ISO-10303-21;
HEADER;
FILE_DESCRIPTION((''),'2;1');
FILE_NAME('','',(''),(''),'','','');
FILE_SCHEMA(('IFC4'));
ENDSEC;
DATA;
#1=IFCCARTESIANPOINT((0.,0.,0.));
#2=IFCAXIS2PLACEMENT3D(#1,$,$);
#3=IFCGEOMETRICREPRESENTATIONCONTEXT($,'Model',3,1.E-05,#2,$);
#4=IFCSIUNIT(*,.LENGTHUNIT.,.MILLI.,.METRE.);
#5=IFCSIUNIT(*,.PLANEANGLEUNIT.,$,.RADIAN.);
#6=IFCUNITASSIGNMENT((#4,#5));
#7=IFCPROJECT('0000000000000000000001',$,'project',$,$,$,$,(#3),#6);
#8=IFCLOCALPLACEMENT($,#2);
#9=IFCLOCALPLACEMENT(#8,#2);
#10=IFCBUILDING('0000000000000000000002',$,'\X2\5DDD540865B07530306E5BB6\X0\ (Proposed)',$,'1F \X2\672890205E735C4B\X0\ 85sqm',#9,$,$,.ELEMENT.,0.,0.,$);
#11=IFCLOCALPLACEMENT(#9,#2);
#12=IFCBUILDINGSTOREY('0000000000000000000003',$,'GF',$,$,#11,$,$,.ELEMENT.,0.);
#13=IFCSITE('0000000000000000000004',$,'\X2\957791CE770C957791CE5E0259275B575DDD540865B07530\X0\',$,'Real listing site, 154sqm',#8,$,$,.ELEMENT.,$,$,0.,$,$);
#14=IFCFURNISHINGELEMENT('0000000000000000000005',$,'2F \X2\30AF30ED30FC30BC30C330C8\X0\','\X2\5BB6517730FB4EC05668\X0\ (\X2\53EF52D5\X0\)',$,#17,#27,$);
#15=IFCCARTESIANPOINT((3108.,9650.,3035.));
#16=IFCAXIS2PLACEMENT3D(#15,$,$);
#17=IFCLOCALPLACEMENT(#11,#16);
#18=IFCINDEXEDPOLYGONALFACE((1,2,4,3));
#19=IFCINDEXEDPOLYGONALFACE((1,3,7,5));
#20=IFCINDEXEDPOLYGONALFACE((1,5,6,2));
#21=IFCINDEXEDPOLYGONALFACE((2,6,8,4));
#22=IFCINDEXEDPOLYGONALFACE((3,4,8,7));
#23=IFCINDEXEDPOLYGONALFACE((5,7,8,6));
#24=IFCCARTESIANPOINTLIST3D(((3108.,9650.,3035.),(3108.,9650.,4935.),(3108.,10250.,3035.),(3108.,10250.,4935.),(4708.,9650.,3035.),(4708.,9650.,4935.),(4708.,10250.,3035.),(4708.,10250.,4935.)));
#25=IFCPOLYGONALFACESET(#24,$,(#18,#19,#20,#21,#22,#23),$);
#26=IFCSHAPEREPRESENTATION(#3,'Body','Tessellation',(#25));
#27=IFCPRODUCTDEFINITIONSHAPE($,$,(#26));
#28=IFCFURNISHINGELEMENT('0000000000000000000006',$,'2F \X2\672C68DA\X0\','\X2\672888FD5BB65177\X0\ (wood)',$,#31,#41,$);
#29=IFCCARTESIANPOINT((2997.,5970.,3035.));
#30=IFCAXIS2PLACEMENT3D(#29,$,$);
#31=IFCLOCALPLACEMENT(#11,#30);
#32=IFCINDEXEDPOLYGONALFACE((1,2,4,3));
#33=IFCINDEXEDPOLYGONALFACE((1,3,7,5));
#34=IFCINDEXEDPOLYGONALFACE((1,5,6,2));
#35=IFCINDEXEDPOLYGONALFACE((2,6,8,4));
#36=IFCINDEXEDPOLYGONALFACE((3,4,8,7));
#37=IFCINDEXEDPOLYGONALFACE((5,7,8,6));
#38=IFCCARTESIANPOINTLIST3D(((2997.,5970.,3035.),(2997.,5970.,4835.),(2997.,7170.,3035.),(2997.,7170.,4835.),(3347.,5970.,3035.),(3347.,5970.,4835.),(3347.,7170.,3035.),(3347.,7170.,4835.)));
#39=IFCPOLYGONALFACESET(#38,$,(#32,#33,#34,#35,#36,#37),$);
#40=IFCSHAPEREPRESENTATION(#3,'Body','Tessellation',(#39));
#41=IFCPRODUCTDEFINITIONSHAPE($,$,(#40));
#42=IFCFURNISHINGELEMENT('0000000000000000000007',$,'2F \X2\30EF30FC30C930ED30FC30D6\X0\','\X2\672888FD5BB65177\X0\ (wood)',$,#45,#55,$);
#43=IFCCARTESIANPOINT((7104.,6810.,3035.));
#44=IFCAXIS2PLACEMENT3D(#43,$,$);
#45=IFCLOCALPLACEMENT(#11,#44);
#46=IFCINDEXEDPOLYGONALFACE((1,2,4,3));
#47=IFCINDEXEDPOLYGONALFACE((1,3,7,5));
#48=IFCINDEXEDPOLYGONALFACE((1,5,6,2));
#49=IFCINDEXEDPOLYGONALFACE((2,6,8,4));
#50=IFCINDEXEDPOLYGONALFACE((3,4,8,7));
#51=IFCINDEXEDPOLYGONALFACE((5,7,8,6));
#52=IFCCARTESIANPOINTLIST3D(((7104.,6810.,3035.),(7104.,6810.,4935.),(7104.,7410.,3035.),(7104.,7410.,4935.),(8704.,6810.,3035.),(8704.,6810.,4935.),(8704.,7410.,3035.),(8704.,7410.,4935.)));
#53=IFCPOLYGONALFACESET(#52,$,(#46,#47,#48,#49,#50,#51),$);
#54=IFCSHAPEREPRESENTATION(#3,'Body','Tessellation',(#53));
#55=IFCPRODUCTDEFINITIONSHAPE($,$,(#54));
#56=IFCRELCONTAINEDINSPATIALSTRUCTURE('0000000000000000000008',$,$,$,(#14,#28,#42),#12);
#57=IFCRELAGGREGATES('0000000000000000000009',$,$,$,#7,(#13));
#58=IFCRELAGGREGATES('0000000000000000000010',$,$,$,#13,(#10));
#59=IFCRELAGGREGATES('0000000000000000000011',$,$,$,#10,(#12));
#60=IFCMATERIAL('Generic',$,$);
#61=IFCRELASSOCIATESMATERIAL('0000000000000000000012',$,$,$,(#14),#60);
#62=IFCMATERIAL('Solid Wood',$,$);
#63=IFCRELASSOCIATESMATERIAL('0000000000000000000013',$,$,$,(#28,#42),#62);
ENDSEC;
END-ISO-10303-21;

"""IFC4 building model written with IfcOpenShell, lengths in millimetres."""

from ifc_helpers import new_model, si_unit, frame, frame_2d, origin, place, context, project, spatial, rectangle, extrude, material, element, save


model = new_model("IFC4")

# Units and contexts
model_context = context("Model", 3, precision=1e-05, world=origin())
ifc_project = project(units=[si_unit("LENGTHUNIT", "METRE", prefix="MILLI"), si_unit("PLANEANGLEUNIT", "RADIAN")], contexts=[model_context])

# Site, building, storey
site_placement = place(None, origin())
site = spatial("IfcSite", under=ifc_project, at=site_placement, Name="長野県長野市大字川合新田", ObjectType="Real listing site, 154sqm", CompositionType="ELEMENT", RefElevation=0.0)
building_placement = place(site_placement, origin())
building = spatial("IfcBuilding", under=site, at=building_placement, Name="川合新田の家 (Proposed)", ObjectType="1F 木造平屋 85sqm", CompositionType="ELEMENT", ElevationOfRefHeight=0.0, ElevationOfTerrain=0.0)
storey_placement = place(building_placement, origin())
storey = spatial("IfcBuildingStorey", under=building, at=storey_placement, Name="GF", CompositionType="ELEMENT", Elevation=0.0)

# Shared definitions
ifc_material_1 = material(Name="Solid Wood")

# Shared definitions
ifc_material_2 = material(Name="Generic")

# Furnishing elements
furnishing_1_placement = place(storey_placement, frame((3108.0, 9650.0, 3035.0)))
element("IfcFurnishingElement", 1, at=furnishing_1_placement, inside=storey, material=ifc_material_2, Name="2F クローゼット", Description="家具・什器 (可動)", context=model_context, shape_type="SweptSolid", body=[
    extrude(rectangle(XDim=1600.0, YDim=600.0, at=frame_2d((800.0, 300.0))), frame((3108.0, 9650.0, 3035.0)), (0.0, 0.0, 1.0), 1900.0),
])
furnishing_2_placement = place(storey_placement, frame((2997.0, 5970.0, 3035.0)))
element("IfcFurnishingElement", 2, at=furnishing_2_placement, inside=storey, material=ifc_material_1, Name="2F 本棚", Description="木製家具 (wood)", context=model_context, shape_type="SweptSolid", body=[
    extrude(rectangle(XDim=350.0, YDim=1200.0, at=frame_2d((175.0, 600.0))), frame((2997.0, 5970.0, 3035.0)), (0.0, 0.0, 1.0), 1800.0),
])
furnishing_3_placement = place(storey_placement, frame((7104.0, 6810.0, 3035.0)))
element("IfcFurnishingElement", 3, at=furnishing_3_placement, inside=storey, material=ifc_material_1, Name="2F ワードローブ", Description="木製家具 (wood)", context=model_context, shape_type="SweptSolid", body=[
    extrude(rectangle(XDim=1600.0, YDim=600.0, at=frame_2d((800.0, 300.0))), frame((7104.0, 6810.0, 3035.0)), (0.0, 0.0, 1.0), 1900.0),
])

save(model, "model.ifc")
